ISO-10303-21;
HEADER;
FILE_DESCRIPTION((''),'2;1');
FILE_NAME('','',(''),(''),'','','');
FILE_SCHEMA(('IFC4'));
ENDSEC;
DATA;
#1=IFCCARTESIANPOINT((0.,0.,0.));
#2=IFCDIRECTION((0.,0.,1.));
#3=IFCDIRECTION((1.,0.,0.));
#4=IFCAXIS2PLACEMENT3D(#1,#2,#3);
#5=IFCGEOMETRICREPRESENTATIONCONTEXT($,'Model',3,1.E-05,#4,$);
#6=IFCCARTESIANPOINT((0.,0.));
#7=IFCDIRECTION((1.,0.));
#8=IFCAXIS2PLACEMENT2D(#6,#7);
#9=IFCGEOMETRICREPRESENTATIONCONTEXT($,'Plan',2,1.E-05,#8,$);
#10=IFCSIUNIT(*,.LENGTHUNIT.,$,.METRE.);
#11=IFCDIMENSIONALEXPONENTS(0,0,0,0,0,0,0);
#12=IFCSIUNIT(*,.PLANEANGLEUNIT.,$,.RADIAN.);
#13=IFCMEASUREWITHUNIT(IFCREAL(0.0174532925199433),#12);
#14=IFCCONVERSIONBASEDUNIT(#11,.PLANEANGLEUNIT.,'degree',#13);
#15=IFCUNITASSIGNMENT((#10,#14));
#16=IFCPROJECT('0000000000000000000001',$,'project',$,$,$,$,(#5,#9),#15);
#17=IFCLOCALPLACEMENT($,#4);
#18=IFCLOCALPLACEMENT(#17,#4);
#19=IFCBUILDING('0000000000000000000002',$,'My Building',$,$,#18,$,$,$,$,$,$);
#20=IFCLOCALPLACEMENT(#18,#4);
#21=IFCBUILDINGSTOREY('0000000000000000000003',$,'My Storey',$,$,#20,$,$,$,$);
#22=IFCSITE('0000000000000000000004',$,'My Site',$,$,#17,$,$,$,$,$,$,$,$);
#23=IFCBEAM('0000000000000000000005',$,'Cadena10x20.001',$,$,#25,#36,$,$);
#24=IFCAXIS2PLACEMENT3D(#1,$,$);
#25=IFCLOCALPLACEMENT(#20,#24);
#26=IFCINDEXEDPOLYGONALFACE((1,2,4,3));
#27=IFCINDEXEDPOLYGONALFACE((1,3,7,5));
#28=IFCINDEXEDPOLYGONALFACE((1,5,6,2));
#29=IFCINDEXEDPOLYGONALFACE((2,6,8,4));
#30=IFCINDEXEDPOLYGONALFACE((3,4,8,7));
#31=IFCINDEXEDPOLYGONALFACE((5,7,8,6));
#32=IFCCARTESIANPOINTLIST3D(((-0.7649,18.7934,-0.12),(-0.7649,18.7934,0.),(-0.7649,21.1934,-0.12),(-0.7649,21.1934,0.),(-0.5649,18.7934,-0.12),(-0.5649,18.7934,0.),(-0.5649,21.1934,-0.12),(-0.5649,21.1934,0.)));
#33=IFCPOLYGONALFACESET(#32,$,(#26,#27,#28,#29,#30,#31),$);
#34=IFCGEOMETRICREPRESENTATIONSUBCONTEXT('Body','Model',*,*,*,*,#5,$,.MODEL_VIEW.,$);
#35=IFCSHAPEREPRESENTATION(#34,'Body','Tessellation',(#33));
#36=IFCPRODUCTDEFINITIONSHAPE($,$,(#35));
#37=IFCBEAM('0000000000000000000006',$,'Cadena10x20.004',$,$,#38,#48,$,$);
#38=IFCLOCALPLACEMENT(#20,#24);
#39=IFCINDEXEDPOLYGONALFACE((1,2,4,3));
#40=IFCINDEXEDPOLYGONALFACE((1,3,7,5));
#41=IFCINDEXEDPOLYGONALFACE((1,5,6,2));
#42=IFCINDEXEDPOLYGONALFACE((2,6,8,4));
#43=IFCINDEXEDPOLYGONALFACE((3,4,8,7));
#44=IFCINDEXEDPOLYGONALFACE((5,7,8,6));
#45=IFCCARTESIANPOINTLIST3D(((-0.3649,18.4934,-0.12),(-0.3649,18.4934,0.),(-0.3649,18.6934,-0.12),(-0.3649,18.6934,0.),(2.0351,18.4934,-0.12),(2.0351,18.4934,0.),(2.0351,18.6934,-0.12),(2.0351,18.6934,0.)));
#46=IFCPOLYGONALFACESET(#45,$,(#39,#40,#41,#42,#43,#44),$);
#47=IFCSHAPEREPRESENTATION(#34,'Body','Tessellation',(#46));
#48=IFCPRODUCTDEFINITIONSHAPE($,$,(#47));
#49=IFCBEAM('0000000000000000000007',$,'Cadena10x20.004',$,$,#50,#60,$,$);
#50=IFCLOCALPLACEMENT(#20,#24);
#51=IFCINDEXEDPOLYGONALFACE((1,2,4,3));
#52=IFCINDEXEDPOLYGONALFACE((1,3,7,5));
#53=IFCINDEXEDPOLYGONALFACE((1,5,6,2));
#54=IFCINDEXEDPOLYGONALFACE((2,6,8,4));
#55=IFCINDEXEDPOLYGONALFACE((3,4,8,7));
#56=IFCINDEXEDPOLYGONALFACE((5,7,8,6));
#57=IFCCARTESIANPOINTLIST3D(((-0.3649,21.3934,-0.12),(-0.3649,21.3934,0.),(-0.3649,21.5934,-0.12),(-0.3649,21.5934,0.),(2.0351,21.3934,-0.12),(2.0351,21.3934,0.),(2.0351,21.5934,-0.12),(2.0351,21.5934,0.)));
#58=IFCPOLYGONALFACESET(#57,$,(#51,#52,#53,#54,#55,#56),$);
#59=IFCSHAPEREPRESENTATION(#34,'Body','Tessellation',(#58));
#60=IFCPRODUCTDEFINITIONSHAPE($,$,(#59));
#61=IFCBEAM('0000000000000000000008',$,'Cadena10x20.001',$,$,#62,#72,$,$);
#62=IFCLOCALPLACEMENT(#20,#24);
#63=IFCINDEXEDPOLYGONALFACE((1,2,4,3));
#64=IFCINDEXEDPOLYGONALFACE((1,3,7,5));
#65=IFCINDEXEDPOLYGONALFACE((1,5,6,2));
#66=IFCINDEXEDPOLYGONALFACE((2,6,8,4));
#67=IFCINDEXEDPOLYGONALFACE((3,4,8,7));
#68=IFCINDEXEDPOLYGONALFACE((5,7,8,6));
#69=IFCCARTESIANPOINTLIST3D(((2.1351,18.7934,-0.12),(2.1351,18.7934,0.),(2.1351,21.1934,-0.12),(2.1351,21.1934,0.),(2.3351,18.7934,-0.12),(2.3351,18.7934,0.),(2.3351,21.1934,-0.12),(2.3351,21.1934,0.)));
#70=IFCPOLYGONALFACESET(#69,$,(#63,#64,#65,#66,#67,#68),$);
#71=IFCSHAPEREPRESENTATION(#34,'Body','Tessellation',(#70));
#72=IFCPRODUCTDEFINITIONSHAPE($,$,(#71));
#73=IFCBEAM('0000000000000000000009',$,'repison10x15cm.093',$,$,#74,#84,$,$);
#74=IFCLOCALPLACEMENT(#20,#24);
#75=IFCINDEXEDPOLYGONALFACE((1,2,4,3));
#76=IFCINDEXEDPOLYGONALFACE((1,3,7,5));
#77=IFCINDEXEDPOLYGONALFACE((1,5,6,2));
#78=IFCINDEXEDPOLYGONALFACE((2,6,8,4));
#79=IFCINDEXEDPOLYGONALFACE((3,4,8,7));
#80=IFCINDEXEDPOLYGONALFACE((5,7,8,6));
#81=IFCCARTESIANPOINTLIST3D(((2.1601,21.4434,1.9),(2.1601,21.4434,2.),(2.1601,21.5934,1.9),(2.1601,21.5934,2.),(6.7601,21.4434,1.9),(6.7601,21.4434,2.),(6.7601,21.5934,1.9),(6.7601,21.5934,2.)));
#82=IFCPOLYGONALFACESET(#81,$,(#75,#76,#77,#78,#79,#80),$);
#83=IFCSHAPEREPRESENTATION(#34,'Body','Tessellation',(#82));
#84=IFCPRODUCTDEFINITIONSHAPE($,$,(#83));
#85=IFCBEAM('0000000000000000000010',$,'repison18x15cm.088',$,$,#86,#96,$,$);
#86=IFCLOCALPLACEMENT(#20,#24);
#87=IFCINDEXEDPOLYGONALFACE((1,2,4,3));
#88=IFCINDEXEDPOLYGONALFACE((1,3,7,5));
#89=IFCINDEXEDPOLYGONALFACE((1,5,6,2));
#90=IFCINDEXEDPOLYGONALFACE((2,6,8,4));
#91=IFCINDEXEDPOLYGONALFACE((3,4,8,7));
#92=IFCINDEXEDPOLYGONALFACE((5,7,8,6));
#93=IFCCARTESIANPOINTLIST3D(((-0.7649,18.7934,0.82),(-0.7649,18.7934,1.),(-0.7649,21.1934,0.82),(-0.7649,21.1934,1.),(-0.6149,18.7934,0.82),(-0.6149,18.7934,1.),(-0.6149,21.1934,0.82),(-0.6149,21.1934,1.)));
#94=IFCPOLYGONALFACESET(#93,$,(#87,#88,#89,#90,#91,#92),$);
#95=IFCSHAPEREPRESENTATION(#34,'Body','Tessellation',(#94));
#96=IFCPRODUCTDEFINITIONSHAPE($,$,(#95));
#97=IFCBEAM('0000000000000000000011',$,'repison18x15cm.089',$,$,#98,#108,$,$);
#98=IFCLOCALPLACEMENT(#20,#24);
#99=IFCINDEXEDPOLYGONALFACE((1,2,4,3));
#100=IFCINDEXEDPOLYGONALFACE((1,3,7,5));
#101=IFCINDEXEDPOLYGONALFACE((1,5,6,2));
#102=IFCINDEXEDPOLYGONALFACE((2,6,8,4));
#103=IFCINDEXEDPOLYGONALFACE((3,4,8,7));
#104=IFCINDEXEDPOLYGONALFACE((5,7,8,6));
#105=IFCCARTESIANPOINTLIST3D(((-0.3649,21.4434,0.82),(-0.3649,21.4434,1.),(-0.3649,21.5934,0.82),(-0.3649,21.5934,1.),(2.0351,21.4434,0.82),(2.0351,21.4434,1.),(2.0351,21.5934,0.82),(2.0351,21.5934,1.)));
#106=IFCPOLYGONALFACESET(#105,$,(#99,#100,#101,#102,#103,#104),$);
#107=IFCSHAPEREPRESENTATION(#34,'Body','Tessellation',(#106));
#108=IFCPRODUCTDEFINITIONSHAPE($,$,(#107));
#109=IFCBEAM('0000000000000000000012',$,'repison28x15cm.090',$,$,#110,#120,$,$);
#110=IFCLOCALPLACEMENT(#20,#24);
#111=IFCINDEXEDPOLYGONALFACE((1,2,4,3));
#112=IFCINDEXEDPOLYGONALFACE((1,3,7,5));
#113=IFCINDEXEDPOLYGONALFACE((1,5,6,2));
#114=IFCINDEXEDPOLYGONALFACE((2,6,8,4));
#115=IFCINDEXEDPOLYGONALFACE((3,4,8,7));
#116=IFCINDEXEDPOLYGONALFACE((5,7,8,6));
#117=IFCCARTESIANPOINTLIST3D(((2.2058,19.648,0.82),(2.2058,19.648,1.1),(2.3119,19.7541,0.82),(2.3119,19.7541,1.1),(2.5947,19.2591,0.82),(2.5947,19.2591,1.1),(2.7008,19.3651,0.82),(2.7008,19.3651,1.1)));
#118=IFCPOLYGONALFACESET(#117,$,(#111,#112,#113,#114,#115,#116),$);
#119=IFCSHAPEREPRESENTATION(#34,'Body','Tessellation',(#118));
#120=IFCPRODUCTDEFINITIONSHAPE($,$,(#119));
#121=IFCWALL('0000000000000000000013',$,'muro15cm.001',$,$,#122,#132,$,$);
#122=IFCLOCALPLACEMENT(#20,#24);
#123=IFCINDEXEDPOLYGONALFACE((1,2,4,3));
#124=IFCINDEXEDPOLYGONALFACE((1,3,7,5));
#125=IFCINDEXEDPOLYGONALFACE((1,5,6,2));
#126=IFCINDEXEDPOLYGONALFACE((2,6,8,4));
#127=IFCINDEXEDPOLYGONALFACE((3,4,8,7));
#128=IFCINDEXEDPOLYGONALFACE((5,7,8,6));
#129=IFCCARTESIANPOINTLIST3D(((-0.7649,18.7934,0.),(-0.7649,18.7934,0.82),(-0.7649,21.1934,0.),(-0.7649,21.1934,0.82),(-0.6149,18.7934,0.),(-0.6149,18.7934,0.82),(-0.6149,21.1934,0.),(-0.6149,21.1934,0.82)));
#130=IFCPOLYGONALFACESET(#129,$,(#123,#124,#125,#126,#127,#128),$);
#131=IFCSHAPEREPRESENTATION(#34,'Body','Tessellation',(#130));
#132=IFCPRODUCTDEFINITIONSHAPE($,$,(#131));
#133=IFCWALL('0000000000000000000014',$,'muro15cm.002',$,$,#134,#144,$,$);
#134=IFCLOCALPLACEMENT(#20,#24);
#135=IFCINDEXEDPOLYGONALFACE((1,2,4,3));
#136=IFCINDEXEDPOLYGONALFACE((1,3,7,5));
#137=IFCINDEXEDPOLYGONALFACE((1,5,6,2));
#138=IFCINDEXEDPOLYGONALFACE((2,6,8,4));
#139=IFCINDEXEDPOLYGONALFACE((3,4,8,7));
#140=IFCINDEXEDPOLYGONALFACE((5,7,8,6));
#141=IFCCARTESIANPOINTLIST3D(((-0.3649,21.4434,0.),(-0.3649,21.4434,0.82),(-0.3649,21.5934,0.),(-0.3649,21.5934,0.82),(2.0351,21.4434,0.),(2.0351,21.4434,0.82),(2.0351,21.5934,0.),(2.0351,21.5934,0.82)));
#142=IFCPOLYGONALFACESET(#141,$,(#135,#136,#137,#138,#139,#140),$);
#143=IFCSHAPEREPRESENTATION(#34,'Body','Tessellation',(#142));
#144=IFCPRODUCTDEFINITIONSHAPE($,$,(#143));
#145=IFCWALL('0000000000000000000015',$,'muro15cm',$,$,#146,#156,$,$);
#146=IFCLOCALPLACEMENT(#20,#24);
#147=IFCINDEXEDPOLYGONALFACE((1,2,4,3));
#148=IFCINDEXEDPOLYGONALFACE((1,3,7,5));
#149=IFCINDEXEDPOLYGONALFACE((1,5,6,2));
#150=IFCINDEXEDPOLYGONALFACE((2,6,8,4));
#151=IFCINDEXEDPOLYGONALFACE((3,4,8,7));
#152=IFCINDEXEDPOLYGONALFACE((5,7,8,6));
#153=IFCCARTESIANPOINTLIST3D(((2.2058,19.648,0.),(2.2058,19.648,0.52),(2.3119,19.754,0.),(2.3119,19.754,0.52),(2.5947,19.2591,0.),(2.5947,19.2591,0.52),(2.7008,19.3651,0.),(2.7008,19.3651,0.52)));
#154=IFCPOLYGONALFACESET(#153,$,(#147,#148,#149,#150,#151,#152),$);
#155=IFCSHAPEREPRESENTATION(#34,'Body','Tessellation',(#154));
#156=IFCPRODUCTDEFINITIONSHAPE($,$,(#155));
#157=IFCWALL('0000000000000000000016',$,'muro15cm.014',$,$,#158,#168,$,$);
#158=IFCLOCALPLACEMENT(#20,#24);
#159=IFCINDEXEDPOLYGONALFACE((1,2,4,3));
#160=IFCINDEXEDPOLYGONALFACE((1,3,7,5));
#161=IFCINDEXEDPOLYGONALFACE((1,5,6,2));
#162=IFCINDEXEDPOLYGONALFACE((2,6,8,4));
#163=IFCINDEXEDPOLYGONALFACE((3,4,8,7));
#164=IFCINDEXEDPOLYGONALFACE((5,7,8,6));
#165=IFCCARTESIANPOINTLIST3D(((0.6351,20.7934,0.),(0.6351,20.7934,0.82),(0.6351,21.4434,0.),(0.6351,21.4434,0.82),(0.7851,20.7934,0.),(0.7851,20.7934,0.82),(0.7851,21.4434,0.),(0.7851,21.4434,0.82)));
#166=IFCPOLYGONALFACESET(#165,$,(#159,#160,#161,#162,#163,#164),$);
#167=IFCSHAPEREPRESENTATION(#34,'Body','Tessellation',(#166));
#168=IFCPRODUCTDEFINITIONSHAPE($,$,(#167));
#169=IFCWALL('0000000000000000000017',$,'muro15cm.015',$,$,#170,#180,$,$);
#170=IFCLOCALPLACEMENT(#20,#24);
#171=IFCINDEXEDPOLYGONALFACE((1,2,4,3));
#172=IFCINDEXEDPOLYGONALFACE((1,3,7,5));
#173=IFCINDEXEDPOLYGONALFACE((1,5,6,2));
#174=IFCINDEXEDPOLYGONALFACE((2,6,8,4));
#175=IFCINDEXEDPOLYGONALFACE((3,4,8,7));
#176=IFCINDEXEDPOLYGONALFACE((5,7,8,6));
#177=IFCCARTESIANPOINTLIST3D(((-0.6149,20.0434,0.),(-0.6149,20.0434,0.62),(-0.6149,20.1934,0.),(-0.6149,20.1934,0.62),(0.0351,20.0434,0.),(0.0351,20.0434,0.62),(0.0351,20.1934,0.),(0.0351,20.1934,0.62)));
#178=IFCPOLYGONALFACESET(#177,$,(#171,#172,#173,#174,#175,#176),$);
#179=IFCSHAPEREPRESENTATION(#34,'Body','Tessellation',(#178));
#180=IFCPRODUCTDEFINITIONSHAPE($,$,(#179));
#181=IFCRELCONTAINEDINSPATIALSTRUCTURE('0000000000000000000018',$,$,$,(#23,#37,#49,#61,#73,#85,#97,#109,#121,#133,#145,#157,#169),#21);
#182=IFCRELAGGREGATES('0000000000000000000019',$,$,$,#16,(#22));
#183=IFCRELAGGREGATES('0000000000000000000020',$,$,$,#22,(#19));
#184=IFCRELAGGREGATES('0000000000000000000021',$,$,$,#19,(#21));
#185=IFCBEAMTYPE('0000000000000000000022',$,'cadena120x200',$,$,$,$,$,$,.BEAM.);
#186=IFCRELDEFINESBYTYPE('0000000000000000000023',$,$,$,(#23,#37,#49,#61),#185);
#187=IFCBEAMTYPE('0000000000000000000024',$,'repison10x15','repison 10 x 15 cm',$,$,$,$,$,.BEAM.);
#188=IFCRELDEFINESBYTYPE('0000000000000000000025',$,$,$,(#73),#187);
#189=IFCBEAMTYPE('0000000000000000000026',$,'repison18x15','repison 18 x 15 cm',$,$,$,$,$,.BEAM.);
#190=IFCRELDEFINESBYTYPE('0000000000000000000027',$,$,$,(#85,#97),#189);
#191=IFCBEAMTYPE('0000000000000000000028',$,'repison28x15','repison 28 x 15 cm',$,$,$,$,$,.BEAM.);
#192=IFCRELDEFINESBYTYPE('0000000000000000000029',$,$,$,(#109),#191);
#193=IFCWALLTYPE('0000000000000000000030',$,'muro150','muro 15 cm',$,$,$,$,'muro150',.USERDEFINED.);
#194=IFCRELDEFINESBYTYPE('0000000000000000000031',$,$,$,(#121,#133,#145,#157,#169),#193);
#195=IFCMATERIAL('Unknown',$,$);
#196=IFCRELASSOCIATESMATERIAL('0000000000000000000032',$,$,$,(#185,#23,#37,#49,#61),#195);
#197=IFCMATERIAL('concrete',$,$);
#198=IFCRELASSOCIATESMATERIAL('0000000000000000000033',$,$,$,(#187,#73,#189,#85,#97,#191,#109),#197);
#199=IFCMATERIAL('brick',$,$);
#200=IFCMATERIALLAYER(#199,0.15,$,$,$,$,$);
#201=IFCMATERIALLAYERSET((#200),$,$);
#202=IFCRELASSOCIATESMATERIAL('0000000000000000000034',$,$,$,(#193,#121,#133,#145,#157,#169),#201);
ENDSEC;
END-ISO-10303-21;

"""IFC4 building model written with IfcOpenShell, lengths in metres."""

from ifc_helpers import new_model, entity, si_unit, converted_unit, frame, origin_with_axes, origin_2d_with_axis, place, context, subcontext, project, spatial, indexed_curve, rectangle, outline, extrude, material, layer, layer_set, layer_usage, material_profile, profile_set, profile_usage, type_object, element, save


model = new_model("IFC4")

# Units and contexts
model_context = context("Model", 3, precision=1e-05, world=origin_with_axes())
plan_context = context("Plan", 2, precision=1e-05, world=origin_2d_with_axis())
body_context = subcontext(model_context, "Body", "Model", "MODEL_VIEW")
ifc_project = project(units=[si_unit("LENGTHUNIT", "METRE"), converted_unit("PLANEANGLEUNIT", "degree", entity("IfcReal", 0.0174532925199433), si_unit("PLANEANGLEUNIT", "RADIAN"), dimensions=[0, 0, 0, 0, 0, 0, 0])], contexts=[model_context, plan_context])

# Site, building, storey
site_placement = place(None, origin_with_axes())
site = spatial("IfcSite", under=ifc_project, at=site_placement, Name="My Site")
building_placement = place(site_placement, origin_with_axes())
building = spatial("IfcBuilding", under=site, at=building_placement, Name="My Building")
storey_placement = place(building_placement, origin_with_axes())
storey = spatial("IfcBuildingStorey", under=building, at=storey_placement, Name="My Storey")

# Shared definitions
ifc_material_1 = material(Name="concrete")

# Beams
ifc_material_2 = material(Name="Unknown")
ifc_material_profile_1 = material_profile(ifc_material_2, rectangle(XDim=0.2, YDim=0.12))
ifc_profile_set_1 = profile_set([ifc_material_profile_1], Name="concrete")
ifc_profile_usage_1 = profile_usage(ifc_profile_set_1, cardinal=5)
beam_type_1 = type_object("IfcBeamType", Name="cadena120x200", PredefinedType="BEAM", material=ifc_profile_set_1)
beam_1_placement = place(storey_placement, frame((-0.6649, 21.1934, -0.06), z_axis=(0.0, -1.0, 0.0), x_axis=(1.0, 0.0, 0.0)))
element("IfcBeam", 1, at=beam_1_placement, inside=storey, type_object=beam_type_1, material=ifc_profile_usage_1, Name="Cadena10x20.001", context=body_context, shape_type="SweptSolid", body=[
    extrude(rectangle(XDim=0.2, YDim=0.12), origin_with_axes(), (0.0, 0.0, 1.0), 2.4),
])
ifc_profile_usage_2 = profile_usage(ifc_profile_set_1, cardinal=5)
beam_2_placement = place(storey_placement, frame((-0.3649, 18.5934, -0.06), z_axis=(1.0, -0.000001, 0.000001), x_axis=(0.000001, 1.0, 0.0)))
element("IfcBeam", 2, at=beam_2_placement, inside=storey, type_object=beam_type_1, material=ifc_profile_usage_2, Name="Cadena10x20.004", context=body_context, shape_type="SweptSolid", body=[
    extrude(rectangle(XDim=0.2, YDim=0.12), origin_with_axes(), (0.0, 0.0, 1.0), 2.4),
])
ifc_profile_usage_3 = profile_usage(ifc_profile_set_1, cardinal=5)
beam_3_placement = place(storey_placement, frame((-0.3649, 21.4934, -0.06), z_axis=(1.0, -0.000001, 0.000001), x_axis=(0.000001, 1.0, 0.0)))
element("IfcBeam", 3, at=beam_3_placement, inside=storey, type_object=beam_type_1, material=ifc_profile_usage_3, Name="Cadena10x20.004", context=body_context, shape_type="SweptSolid", body=[
    extrude(rectangle(XDim=0.2, YDim=0.12), origin_with_axes(), (0.0, 0.0, 1.0), 2.4),
])
ifc_profile_usage_4 = profile_usage(ifc_profile_set_1, cardinal=5)
beam_4_placement = place(storey_placement, frame((2.2351, 21.1934, -0.06), z_axis=(0.0, -1.0, 0.0), x_axis=(1.0, 0.0, 0.0)))
element("IfcBeam", 4, at=beam_4_placement, inside=storey, type_object=beam_type_1, material=ifc_profile_usage_4, Name="Cadena10x20.001", context=body_context, shape_type="SweptSolid", body=[
    extrude(rectangle(XDim=0.2, YDim=0.12), origin_with_axes(), (0.0, 0.0, 1.0), 2.4),
])
ifc_material_profile_2 = material_profile(ifc_material_1, rectangle(XDim=0.15, YDim=0.1))
ifc_profile_set_2 = profile_set([ifc_material_profile_2])
ifc_profile_usage_5 = profile_usage(ifc_profile_set_2, cardinal=5)
beam_type_2 = type_object("IfcBeamType", Name="repison10x15", Description="repison 10 x 15 cm", PredefinedType="BEAM", material=ifc_profile_set_2)
beam_5_placement = place(storey_placement, frame((2.1601, 21.5184, 1.95), z_axis=(1.0, 0.0, 0.0), x_axis=(0.0, 1.0, 0.0)))
element("IfcBeam", 5, at=beam_5_placement, inside=storey, type_object=beam_type_2, material=ifc_profile_usage_5, Name="repison10x15cm.093", context=body_context, shape_type="SweptSolid", body=[
    extrude(rectangle(XDim=0.15, YDim=0.1), origin_with_axes(), (0.0, 0.0, 1.0), 4.6),
])
ifc_material_profile_3 = material_profile(ifc_material_1, rectangle(XDim=0.15, YDim=0.18), Name="concrete")
ifc_profile_set_3 = profile_set([ifc_material_profile_3], Name="concrete")
ifc_profile_usage_6 = profile_usage(ifc_profile_set_3, cardinal=5)
beam_type_3 = type_object("IfcBeamType", Name="repison18x15", Description="repison 18 x 15 cm", PredefinedType="BEAM", material=ifc_profile_set_3)
beam_6_placement = place(storey_placement, frame((-0.6899, 18.7934, 0.91), z_axis=(0.0, 1.0, 0.0), x_axis=(-1.0, 0.0, 0.0)))
element("IfcBeam", 6, at=beam_6_placement, inside=storey, type_object=beam_type_3, material=ifc_profile_usage_6, Name="repison18x15cm.088", context=body_context, shape_type="SweptSolid", body=[
    extrude(rectangle(XDim=0.15, YDim=0.18), origin_with_axes(), (0.0, 0.0, 1.0), 2.4),
])
ifc_profile_usage_7 = profile_usage(ifc_profile_set_3, cardinal=5)
beam_7_placement = place(storey_placement, frame((-0.3649, 21.5184, 0.91), z_axis=(1.0, 0.0, 0.0), x_axis=(0.0, 1.0, 0.0)))
element("IfcBeam", 7, at=beam_7_placement, inside=storey, type_object=beam_type_3, material=ifc_profile_usage_7, Name="repison18x15cm.089", context=body_context, shape_type="SweptSolid", body=[
    extrude(rectangle(XDim=0.15, YDim=0.18), origin_with_axes(), (0.0, 0.0, 1.0), 2.4),
])
ifc_material_profile_4 = material_profile(ifc_material_1, rectangle(XDim=0.15, YDim=0.28))
ifc_profile_set_4 = profile_set([ifc_material_profile_4])
ifc_profile_usage_8 = profile_usage(ifc_profile_set_4, cardinal=5)
beam_type_4 = type_object("IfcBeamType", Name="repison28x15", Description="repison 28 x 15 cm", PredefinedType="BEAM", material=ifc_profile_set_4)
beam_8_placement = place(storey_placement, frame((2.2589, 19.701, 0.96), z_axis=(0.707107, -0.707107, 0.0), x_axis=(0.707107, 0.707107, 0.0)))
element("IfcBeam", 8, at=beam_8_placement, inside=storey, type_object=beam_type_4, material=ifc_profile_usage_8, Name="repison28x15cm.090", context=body_context, shape_type="SweptSolid", body=[
    extrude(rectangle(XDim=0.15, YDim=0.28), origin_with_axes(), (0.0, 0.0, 1.0), 0.55),
])

# Walls
ifc_material_3 = material(Name="brick")
ifc_layer = layer(ifc_material_3, 0.15)
ifc_layer_set = layer_set([ifc_layer])
ifc_layer_usage_1 = layer_usage(ifc_layer_set, "AXIS2", "POSITIVE", 0.0)
wall_type = type_object("IfcWallType", Name="muro150", Description="muro 15 cm", ElementType="muro150", PredefinedType="USERDEFINED", material=ifc_layer_set)
wall_1_placement = place(storey_placement, frame((-0.7649, 21.1934, 0.0), z_axis=(0.0, 0.0, 1.0), x_axis=(0.0, -1.0, 0.0)))
element("IfcWall", 9, at=wall_1_placement, inside=storey, type_object=wall_type, material=ifc_layer_usage_1, Name="muro15cm.001", context=body_context, shape_type="SweptSolid", body=[
    extrude(outline(indexed_curve([(0.0, 0.0), (0.0, 0.15), (2.4, 0.15), (2.4, 0.0), (0.0, 0.0)], self_intersect=False)), origin_with_axes(), (0.0, 0.0, 1.0), 0.82),
])
ifc_layer_usage_2 = layer_usage(ifc_layer_set, "AXIS2", "POSITIVE", 0.0)
wall_2_placement = place(storey_placement, frame((2.0351, 21.5934, 0.0), z_axis=(0.0, 0.0, 1.0), x_axis=(-1.0, 0.0, 0.0)))
element("IfcWall", 10, at=wall_2_placement, inside=storey, type_object=wall_type, material=ifc_layer_usage_2, Name="muro15cm.002", context=body_context, shape_type="SweptSolid", body=[
    extrude(outline(indexed_curve([(0.0, 0.0), (0.0, 0.15), (2.4, 0.15), (2.4, 0.0), (0.0, 0.0)], self_intersect=False)), origin_with_axes(), (0.0, 0.0, 1.0), 0.82),
])
ifc_layer_usage_3 = layer_usage(ifc_layer_set, "AXIS2", "POSITIVE", 0.0)
wall_3_placement = place(storey_placement, frame((2.2058, 19.648, 0.0), z_axis=(0.0, 0.0, 1.0), x_axis=(0.707107, -0.707107, 0.0)))
element("IfcWall", 11, at=wall_3_placement, inside=storey, type_object=wall_type, material=ifc_layer_usage_3, Name="muro15cm", context=body_context, shape_type="SweptSolid", body=[
    extrude(outline(indexed_curve([(0.0, 0.0), (0.0, 0.15), (0.55, 0.15), (0.55, 0.0), (0.0, 0.0)], self_intersect=False)), origin_with_axes(), (0.0, 0.0, 1.0), 0.52),
])
ifc_layer_usage_4 = layer_usage(ifc_layer_set, "AXIS2", "POSITIVE", 0.0)
wall_4_placement = place(storey_placement, frame((0.7851, 20.7934, 0.0), z_axis=(0.0, 0.0, 1.0), x_axis=(0.0, 1.0, 0.0)))
element("IfcWall", 12, at=wall_4_placement, inside=storey, type_object=wall_type, material=ifc_layer_usage_4, Name="muro15cm.014", context=body_context, shape_type="SweptSolid", body=[
    extrude(outline(indexed_curve([(0.0, 0.0), (0.0, 0.15), (0.65, 0.15), (0.65, 0.0), (0.0, 0.0)], self_intersect=False)), origin_with_axes(), (0.0, 0.0, 1.0), 0.82),
])
ifc_layer_usage_5 = layer_usage(ifc_layer_set, "AXIS2", "POSITIVE", 0.0)
wall_5_placement = place(storey_placement, frame((0.0351, 20.1934, 0.0), z_axis=(0.0, 0.0, 1.0), x_axis=(-1.0, 0.0, 0.0)))
element("IfcWall", 13, at=wall_5_placement, inside=storey, type_object=wall_type, material=ifc_layer_usage_5, Name="muro15cm.015", context=body_context, shape_type="SweptSolid", body=[
    extrude(outline(indexed_curve([(0.0, 0.0), (0.0, 0.15), (0.65, 0.15), (0.65, 0.0), (0.0, 0.0)], self_intersect=False)), origin_with_axes(), (0.0, 0.0, 1.0), 0.62),
])

save(model, "model.ifc")
